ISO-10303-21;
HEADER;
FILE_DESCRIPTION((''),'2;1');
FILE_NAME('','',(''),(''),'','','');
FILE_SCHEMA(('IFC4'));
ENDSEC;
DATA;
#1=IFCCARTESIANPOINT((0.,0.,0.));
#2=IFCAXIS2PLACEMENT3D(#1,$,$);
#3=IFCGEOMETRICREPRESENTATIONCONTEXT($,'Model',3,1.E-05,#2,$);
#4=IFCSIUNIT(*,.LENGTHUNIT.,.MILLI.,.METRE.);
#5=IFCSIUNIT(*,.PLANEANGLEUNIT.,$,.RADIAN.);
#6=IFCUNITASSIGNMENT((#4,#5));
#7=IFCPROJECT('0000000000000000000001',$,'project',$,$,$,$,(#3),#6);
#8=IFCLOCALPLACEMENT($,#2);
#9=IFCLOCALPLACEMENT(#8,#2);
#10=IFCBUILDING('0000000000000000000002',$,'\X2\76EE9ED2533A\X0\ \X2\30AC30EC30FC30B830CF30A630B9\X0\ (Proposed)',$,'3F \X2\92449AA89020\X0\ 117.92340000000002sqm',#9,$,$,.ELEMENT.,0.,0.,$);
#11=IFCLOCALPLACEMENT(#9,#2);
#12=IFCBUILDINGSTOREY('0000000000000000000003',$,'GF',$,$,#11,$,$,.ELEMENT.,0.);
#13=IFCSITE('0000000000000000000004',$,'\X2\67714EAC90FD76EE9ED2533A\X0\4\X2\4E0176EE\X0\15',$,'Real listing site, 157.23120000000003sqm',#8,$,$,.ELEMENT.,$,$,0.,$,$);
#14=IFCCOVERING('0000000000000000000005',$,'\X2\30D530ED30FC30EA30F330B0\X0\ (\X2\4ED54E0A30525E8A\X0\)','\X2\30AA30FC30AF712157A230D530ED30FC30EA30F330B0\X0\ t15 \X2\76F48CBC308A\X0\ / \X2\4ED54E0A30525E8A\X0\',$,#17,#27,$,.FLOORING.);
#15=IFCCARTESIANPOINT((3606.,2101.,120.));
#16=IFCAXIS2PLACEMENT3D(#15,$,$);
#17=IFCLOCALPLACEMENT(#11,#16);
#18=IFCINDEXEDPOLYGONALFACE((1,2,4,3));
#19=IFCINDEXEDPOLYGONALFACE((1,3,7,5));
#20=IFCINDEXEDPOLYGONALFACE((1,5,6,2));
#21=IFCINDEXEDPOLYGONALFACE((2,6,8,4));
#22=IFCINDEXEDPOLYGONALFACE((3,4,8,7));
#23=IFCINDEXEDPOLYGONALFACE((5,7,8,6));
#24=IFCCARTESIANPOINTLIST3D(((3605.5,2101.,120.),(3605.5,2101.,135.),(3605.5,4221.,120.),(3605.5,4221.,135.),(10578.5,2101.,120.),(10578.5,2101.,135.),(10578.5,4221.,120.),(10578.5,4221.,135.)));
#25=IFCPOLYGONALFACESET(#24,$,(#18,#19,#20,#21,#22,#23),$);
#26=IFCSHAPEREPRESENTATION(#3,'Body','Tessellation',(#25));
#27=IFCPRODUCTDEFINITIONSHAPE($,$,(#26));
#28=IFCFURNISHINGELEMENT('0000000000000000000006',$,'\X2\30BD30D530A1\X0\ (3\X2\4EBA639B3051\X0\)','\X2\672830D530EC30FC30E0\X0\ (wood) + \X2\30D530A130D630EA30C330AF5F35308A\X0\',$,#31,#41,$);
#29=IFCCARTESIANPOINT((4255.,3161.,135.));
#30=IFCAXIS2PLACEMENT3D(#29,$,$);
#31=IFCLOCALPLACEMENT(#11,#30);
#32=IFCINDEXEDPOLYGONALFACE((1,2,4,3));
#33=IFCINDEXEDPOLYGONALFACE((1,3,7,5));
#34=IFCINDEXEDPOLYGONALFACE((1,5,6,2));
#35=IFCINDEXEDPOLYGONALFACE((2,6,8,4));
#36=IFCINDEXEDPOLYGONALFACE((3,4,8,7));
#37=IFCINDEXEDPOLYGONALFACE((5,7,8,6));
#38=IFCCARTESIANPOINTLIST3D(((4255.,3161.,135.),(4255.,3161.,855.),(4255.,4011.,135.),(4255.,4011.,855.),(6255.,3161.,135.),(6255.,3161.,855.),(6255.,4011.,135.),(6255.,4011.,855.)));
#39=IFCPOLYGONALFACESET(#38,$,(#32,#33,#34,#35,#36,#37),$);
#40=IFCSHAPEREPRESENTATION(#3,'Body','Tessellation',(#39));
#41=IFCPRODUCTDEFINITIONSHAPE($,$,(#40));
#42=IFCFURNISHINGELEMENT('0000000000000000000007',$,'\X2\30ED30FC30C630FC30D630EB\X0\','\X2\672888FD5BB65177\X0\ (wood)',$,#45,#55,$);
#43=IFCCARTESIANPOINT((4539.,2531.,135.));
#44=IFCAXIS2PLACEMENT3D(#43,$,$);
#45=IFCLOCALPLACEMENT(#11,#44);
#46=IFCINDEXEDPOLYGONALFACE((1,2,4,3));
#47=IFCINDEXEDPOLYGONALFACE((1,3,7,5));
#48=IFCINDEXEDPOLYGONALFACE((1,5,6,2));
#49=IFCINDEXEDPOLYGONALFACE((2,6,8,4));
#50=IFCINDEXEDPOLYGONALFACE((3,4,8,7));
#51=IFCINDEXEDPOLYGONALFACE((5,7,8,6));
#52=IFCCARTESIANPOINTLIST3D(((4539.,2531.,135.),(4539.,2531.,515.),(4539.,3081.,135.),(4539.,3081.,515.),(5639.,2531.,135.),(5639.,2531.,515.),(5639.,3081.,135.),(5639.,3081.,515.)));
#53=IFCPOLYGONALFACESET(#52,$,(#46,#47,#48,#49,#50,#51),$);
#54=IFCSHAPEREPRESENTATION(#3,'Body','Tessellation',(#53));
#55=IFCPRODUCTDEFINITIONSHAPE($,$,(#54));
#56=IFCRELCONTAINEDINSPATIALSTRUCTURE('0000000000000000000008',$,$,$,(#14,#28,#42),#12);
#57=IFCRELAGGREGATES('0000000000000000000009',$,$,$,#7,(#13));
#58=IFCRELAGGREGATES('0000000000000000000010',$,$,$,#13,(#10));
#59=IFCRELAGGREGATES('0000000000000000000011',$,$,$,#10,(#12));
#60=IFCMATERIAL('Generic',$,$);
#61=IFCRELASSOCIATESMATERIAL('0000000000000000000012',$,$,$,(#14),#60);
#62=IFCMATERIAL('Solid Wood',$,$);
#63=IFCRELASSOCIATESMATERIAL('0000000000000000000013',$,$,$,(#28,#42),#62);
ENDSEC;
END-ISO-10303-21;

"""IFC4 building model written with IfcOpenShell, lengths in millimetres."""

from ifc_helpers import new_model, si_unit, frame, frame_2d, origin, place, context, project, spatial, rectangle, extrude, material, element, save


model = new_model("IFC4")

# Units and contexts
model_context = context("Model", 3, precision=1e-05, world=origin())
ifc_project = project(units=[si_unit("LENGTHUNIT", "METRE", prefix="MILLI"), si_unit("PLANEANGLEUNIT", "RADIAN")], contexts=[model_context])

# Site, building, storey
site_placement = place(None, origin())
site = spatial("IfcSite", under=ifc_project, at=site_placement, Name="東京都目黒区4丁目15", ObjectType="Real listing site, 157.23120000000003sqm", CompositionType="ELEMENT", RefElevation=0.0)
building_placement = place(site_placement, origin())
building = spatial("IfcBuilding", under=site, at=building_placement, Name="目黒区 ガレージハウス (Proposed)", ObjectType="3F 鉄骨造 117.92340000000002sqm", CompositionType="ELEMENT", ElevationOfRefHeight=0.0, ElevationOfTerrain=0.0)
storey_placement = place(building_placement, origin())
storey = spatial("IfcBuildingStorey", under=building, at=storey_placement, Name="GF", CompositionType="ELEMENT", Elevation=0.0)

# Shared definitions
ifc_material_1 = material(Name="Solid Wood")

# Covering
ifc_material_2 = material(Name="Generic")
covering_placement = place(storey_placement, frame((3606.0, 2101.0, 120.0)))
element("IfcCovering", 1, at=covering_placement, inside=storey, material=ifc_material_2, Name="フローリング (仕上げ床)", Description="オーク無垢フローリング t15 直貼り / 仕上げ床", PredefinedType="FLOORING", context=model_context, shape_type="SweptSolid", body=[
    extrude(rectangle(XDim=6973.0, YDim=2120.0, at=frame_2d((3486.0, 1060.0))), frame((3606.0, 2101.0, 120.0)), (0.0, 0.0, 1.0), 15.0),
])

# Furnishing elements
furnishing_1_placement = place(storey_placement, frame((4255.0, 3161.0, 135.0)))
element("IfcFurnishingElement", 2, at=furnishing_1_placement, inside=storey, material=ifc_material_1, Name="ソファ (3人掛け)", Description="木フレーム (wood) + ファブリック張り", context=model_context, shape_type="SweptSolid", body=[
    extrude(rectangle(XDim=2000.0, YDim=850.0, at=frame_2d((1000.0, 425.0))), frame((4255.0, 3161.0, 135.0)), (0.0, 0.0, 1.0), 720.0),
])
furnishing_2_placement = place(storey_placement, frame((4539.0, 2531.0, 135.0)))
element("IfcFurnishingElement", 3, at=furnishing_2_placement, inside=storey, material=ifc_material_1, Name="ローテーブル", Description="木製家具 (wood)", context=model_context, shape_type="SweptSolid", body=[
    extrude(rectangle(XDim=1100.0, YDim=550.0, at=frame_2d((550.0, 275.0))), frame((4539.0, 2531.0, 135.0)), (0.0, 0.0, 1.0), 380.0),
])

save(model, "model.ifc")
